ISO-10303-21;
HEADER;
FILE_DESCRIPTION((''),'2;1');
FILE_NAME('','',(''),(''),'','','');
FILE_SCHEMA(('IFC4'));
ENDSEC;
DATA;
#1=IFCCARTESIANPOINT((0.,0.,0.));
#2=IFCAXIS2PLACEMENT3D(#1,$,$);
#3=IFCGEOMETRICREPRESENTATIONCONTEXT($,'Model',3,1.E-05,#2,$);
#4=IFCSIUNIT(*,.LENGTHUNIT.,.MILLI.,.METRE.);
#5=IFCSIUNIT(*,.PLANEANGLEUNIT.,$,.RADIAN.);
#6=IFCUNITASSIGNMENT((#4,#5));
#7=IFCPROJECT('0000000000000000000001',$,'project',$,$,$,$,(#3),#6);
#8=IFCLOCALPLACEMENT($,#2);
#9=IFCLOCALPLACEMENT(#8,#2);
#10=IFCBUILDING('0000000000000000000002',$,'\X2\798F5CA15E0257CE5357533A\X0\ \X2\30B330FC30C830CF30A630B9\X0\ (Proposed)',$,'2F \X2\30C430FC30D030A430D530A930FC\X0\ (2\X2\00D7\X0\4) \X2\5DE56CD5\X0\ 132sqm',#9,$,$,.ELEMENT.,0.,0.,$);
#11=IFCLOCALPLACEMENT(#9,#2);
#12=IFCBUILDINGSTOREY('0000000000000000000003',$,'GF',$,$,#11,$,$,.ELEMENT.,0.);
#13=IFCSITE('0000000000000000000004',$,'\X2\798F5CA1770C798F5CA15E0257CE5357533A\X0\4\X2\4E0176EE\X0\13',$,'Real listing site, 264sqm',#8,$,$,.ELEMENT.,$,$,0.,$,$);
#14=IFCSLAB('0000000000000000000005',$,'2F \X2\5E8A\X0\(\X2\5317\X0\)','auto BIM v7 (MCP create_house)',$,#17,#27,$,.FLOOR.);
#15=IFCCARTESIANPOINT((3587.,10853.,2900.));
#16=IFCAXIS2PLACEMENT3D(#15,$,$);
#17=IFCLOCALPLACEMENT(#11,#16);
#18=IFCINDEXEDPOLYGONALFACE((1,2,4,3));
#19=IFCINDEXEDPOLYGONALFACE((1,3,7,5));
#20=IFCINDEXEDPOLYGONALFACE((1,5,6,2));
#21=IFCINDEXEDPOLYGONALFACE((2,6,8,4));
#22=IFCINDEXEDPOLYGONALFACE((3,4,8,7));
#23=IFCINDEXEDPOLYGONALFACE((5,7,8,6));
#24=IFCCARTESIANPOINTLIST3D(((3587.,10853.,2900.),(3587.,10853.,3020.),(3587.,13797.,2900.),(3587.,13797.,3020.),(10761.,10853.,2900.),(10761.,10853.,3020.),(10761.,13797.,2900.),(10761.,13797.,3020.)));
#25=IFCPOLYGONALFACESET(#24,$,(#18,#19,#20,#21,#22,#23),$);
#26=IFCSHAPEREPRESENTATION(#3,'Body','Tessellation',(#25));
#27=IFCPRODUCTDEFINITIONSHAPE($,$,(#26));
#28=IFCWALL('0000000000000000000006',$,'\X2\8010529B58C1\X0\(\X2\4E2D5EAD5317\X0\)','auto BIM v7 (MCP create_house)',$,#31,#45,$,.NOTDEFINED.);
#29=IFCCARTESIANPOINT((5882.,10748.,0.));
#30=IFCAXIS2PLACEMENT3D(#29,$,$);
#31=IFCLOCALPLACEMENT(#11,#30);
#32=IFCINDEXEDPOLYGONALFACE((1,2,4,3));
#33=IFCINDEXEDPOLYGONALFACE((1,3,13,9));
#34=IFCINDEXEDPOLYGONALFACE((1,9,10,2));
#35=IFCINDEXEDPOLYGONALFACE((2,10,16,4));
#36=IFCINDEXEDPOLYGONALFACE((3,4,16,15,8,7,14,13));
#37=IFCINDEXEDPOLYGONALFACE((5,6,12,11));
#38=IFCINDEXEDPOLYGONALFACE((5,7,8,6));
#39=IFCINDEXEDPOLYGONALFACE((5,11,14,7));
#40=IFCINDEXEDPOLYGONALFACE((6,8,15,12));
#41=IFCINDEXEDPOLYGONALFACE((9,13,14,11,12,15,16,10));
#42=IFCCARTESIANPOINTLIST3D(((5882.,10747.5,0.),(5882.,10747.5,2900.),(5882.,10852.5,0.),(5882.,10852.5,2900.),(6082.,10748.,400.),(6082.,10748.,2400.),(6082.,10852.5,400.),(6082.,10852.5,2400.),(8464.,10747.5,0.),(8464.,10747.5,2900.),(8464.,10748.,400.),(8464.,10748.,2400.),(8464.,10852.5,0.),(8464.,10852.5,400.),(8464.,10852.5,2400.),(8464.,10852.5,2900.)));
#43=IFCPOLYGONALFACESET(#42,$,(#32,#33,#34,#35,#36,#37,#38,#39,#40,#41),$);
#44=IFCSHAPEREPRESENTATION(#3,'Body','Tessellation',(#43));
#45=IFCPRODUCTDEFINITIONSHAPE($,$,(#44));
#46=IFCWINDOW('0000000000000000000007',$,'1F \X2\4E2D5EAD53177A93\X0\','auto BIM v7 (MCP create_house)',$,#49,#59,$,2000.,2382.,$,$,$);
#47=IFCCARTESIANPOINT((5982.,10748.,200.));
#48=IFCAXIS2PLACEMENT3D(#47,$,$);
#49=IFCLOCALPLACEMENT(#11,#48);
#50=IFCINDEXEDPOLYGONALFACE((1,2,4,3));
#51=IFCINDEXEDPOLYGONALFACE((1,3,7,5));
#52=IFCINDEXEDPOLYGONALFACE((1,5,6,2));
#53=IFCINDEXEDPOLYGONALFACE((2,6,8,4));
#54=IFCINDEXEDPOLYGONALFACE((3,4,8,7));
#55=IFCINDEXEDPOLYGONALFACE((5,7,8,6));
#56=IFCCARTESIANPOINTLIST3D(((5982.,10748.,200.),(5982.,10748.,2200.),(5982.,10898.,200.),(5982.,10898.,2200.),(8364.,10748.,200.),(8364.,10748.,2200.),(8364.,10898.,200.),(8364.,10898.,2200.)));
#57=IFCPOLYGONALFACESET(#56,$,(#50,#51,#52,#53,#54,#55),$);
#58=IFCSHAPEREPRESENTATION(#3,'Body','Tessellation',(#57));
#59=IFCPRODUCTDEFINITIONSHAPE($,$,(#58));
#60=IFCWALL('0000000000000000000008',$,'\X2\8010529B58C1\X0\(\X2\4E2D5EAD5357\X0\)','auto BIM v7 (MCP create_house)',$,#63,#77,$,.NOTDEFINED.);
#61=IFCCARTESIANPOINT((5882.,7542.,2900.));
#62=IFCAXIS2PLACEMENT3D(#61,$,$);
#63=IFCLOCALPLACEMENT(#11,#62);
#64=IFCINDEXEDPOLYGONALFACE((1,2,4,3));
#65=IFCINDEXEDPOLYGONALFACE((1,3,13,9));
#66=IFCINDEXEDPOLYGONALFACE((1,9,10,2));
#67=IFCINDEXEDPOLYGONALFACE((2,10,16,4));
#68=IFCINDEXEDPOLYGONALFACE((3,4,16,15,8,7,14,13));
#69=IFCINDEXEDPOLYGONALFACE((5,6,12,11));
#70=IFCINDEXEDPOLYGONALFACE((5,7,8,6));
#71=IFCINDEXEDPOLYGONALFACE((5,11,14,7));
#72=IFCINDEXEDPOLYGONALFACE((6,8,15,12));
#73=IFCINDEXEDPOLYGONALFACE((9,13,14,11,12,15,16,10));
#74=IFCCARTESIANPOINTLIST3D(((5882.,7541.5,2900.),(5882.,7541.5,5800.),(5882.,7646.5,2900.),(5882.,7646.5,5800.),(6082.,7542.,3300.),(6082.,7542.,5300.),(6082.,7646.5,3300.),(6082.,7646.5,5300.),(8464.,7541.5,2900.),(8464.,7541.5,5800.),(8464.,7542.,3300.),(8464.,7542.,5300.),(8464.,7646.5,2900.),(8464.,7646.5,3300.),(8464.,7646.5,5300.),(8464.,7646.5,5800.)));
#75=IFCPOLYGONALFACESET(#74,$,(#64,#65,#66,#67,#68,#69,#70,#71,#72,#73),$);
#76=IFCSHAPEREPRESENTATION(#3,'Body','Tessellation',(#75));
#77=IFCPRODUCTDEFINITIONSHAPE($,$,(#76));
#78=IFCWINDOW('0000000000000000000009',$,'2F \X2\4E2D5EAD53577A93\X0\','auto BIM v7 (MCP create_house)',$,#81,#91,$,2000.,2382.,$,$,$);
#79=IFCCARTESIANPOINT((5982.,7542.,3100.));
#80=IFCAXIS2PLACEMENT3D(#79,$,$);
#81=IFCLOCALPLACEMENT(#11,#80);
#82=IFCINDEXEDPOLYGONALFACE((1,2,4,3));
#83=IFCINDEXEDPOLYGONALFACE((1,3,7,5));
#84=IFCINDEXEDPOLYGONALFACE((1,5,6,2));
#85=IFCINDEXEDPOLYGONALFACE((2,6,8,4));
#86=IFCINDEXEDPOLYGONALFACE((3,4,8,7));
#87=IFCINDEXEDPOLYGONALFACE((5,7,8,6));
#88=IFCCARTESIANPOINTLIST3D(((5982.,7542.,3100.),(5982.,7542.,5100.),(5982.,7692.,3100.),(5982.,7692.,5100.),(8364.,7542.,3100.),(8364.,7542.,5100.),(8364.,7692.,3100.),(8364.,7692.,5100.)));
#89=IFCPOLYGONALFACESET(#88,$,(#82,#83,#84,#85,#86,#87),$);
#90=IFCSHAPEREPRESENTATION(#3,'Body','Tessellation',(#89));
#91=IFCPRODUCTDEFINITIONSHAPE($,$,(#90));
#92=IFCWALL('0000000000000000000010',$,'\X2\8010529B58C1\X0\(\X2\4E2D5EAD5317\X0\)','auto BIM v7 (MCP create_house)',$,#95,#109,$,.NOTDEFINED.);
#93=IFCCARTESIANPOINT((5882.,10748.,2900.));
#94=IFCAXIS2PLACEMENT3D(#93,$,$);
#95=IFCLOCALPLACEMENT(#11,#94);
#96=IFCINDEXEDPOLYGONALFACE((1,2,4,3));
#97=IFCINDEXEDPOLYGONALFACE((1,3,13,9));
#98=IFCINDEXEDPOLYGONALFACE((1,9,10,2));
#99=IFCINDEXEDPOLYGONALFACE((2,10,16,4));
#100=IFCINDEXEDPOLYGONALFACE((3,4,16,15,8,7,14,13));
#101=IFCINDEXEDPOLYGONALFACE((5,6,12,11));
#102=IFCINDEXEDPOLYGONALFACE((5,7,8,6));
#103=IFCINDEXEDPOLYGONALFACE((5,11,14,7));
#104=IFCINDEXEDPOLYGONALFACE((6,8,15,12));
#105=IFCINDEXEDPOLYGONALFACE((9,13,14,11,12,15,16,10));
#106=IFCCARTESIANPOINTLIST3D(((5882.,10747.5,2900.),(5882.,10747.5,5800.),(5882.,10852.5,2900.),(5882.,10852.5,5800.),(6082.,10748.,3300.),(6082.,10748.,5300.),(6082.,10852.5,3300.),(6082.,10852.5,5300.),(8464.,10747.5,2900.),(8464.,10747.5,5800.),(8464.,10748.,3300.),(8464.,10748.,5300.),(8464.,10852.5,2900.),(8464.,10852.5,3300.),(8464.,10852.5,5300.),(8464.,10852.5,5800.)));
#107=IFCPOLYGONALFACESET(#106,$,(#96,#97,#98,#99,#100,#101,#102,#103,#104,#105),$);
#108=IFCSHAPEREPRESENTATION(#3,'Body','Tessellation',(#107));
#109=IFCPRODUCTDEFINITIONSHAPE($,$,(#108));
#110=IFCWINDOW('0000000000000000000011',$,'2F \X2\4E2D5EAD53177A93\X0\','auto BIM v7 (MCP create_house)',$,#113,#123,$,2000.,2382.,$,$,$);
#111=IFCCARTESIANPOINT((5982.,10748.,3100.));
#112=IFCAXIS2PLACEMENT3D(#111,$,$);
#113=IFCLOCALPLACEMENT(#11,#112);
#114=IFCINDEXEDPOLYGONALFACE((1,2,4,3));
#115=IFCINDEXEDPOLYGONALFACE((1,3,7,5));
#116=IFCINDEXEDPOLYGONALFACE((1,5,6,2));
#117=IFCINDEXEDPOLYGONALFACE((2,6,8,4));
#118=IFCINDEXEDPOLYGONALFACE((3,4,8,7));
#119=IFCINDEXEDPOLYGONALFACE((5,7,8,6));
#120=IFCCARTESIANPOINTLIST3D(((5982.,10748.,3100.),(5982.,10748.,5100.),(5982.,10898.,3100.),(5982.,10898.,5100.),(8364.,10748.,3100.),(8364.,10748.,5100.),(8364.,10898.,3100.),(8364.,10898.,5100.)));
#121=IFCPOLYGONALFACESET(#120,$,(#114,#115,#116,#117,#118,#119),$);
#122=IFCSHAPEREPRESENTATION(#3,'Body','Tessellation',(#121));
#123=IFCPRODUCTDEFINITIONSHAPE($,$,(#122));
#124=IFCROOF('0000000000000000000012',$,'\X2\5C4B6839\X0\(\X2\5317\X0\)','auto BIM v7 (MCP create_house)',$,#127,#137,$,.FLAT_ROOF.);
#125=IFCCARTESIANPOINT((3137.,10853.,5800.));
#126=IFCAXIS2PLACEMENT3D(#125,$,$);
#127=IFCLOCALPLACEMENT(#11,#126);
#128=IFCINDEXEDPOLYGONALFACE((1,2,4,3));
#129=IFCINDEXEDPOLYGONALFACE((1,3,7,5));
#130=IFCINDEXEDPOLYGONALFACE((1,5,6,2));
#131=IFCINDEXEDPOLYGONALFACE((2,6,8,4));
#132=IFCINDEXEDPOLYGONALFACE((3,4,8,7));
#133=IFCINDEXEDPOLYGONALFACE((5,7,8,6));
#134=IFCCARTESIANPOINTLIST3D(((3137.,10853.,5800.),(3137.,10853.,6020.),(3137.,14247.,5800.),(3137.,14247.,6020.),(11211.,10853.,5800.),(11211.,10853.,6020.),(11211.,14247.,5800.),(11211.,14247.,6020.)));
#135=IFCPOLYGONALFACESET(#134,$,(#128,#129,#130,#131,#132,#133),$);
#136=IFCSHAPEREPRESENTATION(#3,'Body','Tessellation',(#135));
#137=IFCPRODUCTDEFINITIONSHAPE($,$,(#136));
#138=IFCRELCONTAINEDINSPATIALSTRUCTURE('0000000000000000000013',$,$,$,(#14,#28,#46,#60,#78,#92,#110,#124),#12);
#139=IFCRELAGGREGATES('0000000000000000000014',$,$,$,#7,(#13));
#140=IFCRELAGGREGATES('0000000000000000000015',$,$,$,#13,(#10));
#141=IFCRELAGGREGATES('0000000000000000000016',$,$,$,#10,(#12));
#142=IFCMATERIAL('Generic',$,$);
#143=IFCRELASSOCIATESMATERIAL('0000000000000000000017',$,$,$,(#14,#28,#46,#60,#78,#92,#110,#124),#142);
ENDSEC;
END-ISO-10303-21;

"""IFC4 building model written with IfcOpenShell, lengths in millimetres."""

from ifc_helpers import new_model, si_unit, frame, frame_2d, origin, place, context, project, spatial, rectangle, extrude, material, element, fill, save


model = new_model("IFC4")

# Units and contexts
model_context = context("Model", 3, precision=1e-05, world=origin())
ifc_project = project(units=[si_unit("LENGTHUNIT", "METRE", prefix="MILLI"), si_unit("PLANEANGLEUNIT", "RADIAN")], contexts=[model_context])

# Site, building, storey
site_placement = place(None, origin())
site = spatial("IfcSite", under=ifc_project, at=site_placement, Name="福岡県福岡市城南区4丁目13", ObjectType="Real listing site, 264sqm", CompositionType="ELEMENT", RefElevation=0.0)
building_placement = place(site_placement, origin())
building = spatial("IfcBuilding", under=site, at=building_placement, Name="福岡市城南区 コートハウス (Proposed)", ObjectType="2F ツーバイフォー (2×4) 工法 132sqm", CompositionType="ELEMENT", ElevationOfRefHeight=0.0, ElevationOfTerrain=0.0)
storey_placement = place(building_placement, origin())
storey = spatial("IfcBuildingStorey", under=building, at=storey_placement, Name="GF", CompositionType="ELEMENT", Elevation=0.0)

# Slab
ifc_material = material(Name="Generic")
slab_1_placement = place(storey_placement, frame((3587.0, 10853.0, 2900.0)))
element("IfcSlab", 1, at=slab_1_placement, inside=storey, material=ifc_material, Name="2F 床(北)", Description="auto BIM v7 (MCP create_house)", PredefinedType="FLOOR", context=model_context, shape_type="SweptSolid", body=[
    extrude(rectangle(XDim=7174.0, YDim=2944.0, at=frame_2d((3587.0, 1472.0))), frame((3587.0, 10853.0, 2900.0)), (0.0, 0.0, 1.0), 120.0),
])

# Wall, opening, window
wall_1_placement = place(storey_placement, frame((5882.0, 10748.0, 0.0)))
wall_1 = element("IfcWall", 2, at=wall_1_placement, inside=storey, material=ifc_material, Name="耐力壁(中庭北)", Description="auto BIM v7 (MCP create_house)", PredefinedType="NOTDEFINED", context=model_context, shape_type="SweptSolid", body=[
    extrude(rectangle(XDim=2582.0, YDim=105.0, at=frame_2d((1291.0, 52.0))), frame((5882.0, 10748.0, 0.0)), (0.0, 0.0, 1.0), 2900.0),
])
opening_1_placement = place(storey_placement, frame((5982.0, 10748.0, 200.0)))
opening_1 = element("IfcOpeningElement", 3, at=opening_1_placement, cuts=wall_1, PredefinedType="NOTDEFINED", context=model_context, shape_type="SweptSolid", body=[
    extrude(rectangle(XDim=2382.0, YDim=150.0, at=frame_2d((1191.0, 75.0))), frame((5982.0, 10748.0, 200.0)), (0.0, 0.0, 1.0), 2000.0),
])
window_1_placement = place(storey_placement, frame((5982.0, 10748.0, 200.0)))
window_1 = element("IfcWindow", 4, at=window_1_placement, inside=storey, material=ifc_material, Name="1F 中庭北窓", Description="auto BIM v7 (MCP create_house)", OverallHeight=2000.0, OverallWidth=2382.0, context=model_context, shape_type="SweptSolid", body=[
    extrude(rectangle(XDim=2382.0, YDim=150.0, at=frame_2d((1191.0, 75.0))), frame((5982.0, 10748.0, 200.0)), (0.0, 0.0, 1.0), 2000.0),
])
fill(opening_1, window_1)

# Walls, openings, windows
wall_2_placement = place(storey_placement, frame((5882.0, 7542.0, 2900.0)))
wall_2 = element("IfcWall", 5, at=wall_2_placement, inside=storey, material=ifc_material, Name="耐力壁(中庭南)", Description="auto BIM v7 (MCP create_house)", PredefinedType="NOTDEFINED", context=model_context, shape_type="SweptSolid", body=[
    extrude(rectangle(XDim=2582.0, YDim=105.0, at=frame_2d((1291.0, 52.0))), frame((5882.0, 7542.0, 2900.0)), (0.0, 0.0, 1.0), 2900.0),
])
opening_2_placement = place(storey_placement, frame((5982.0, 7542.0, 3100.0)))
opening_2 = element("IfcOpeningElement", 6, at=opening_2_placement, cuts=wall_2, PredefinedType="NOTDEFINED", context=model_context, shape_type="SweptSolid", body=[
    extrude(rectangle(XDim=2382.0, YDim=150.0, at=frame_2d((1191.0, 75.0))), frame((5982.0, 7542.0, 3100.0)), (0.0, 0.0, 1.0), 2000.0),
])
window_2_placement = place(storey_placement, frame((5982.0, 7542.0, 3100.0)))
window_2 = element("IfcWindow", 7, at=window_2_placement, inside=storey, material=ifc_material, Name="2F 中庭南窓", Description="auto BIM v7 (MCP create_house)", OverallHeight=2000.0, OverallWidth=2382.0, context=model_context, shape_type="SweptSolid", body=[
    extrude(rectangle(XDim=2382.0, YDim=150.0, at=frame_2d((1191.0, 75.0))), frame((5982.0, 7542.0, 3100.0)), (0.0, 0.0, 1.0), 2000.0),
])
fill(opening_2, window_2)
wall_3_placement = place(storey_placement, frame((5882.0, 10748.0, 2900.0)))
wall_3 = element("IfcWall", 8, at=wall_3_placement, inside=storey, material=ifc_material, Name="耐力壁(中庭北)", Description="auto BIM v7 (MCP create_house)", PredefinedType="NOTDEFINED", context=model_context, shape_type="SweptSolid", body=[
    extrude(rectangle(XDim=2582.0, YDim=105.0, at=frame_2d((1291.0, 52.0))), frame((5882.0, 10748.0, 2900.0)), (0.0, 0.0, 1.0), 2900.0),
])
opening_3_placement = place(storey_placement, frame((5982.0, 10748.0, 3100.0)))
opening_3 = element("IfcOpeningElement", 9, at=opening_3_placement, cuts=wall_3, PredefinedType="NOTDEFINED", context=model_context, shape_type="SweptSolid", body=[
    extrude(rectangle(XDim=2382.0, YDim=150.0, at=frame_2d((1191.0, 75.0))), frame((5982.0, 10748.0, 3100.0)), (0.0, 0.0, 1.0), 2000.0),
])
window_3_placement = place(storey_placement, frame((5982.0, 10748.0, 3100.0)))
window_3 = element("IfcWindow", 10, at=window_3_placement, inside=storey, material=ifc_material, Name="2F 中庭北窓", Description="auto BIM v7 (MCP create_house)", OverallHeight=2000.0, OverallWidth=2382.0, context=model_context, shape_type="SweptSolid", body=[
    extrude(rectangle(XDim=2382.0, YDim=150.0, at=frame_2d((1191.0, 75.0))), frame((5982.0, 10748.0, 3100.0)), (0.0, 0.0, 1.0), 2000.0),
])
fill(opening_3, window_3)

# Roof
roof_1_placement = place(storey_placement, frame((3137.0, 10853.0, 5800.0)))
element("IfcRoof", 11, at=roof_1_placement, inside=storey, material=ifc_material, Name="屋根(北)", Description="auto BIM v7 (MCP create_house)", PredefinedType="FLAT_ROOF", context=model_context, shape_type="SweptSolid", body=[
    extrude(rectangle(XDim=8074.0, YDim=3394.0, at=frame_2d((4037.0, 1697.0))), frame((3137.0, 10853.0, 5800.0)), (0.0, 0.0, 1.0), 220.0),
])

save(model, "model.ifc")
